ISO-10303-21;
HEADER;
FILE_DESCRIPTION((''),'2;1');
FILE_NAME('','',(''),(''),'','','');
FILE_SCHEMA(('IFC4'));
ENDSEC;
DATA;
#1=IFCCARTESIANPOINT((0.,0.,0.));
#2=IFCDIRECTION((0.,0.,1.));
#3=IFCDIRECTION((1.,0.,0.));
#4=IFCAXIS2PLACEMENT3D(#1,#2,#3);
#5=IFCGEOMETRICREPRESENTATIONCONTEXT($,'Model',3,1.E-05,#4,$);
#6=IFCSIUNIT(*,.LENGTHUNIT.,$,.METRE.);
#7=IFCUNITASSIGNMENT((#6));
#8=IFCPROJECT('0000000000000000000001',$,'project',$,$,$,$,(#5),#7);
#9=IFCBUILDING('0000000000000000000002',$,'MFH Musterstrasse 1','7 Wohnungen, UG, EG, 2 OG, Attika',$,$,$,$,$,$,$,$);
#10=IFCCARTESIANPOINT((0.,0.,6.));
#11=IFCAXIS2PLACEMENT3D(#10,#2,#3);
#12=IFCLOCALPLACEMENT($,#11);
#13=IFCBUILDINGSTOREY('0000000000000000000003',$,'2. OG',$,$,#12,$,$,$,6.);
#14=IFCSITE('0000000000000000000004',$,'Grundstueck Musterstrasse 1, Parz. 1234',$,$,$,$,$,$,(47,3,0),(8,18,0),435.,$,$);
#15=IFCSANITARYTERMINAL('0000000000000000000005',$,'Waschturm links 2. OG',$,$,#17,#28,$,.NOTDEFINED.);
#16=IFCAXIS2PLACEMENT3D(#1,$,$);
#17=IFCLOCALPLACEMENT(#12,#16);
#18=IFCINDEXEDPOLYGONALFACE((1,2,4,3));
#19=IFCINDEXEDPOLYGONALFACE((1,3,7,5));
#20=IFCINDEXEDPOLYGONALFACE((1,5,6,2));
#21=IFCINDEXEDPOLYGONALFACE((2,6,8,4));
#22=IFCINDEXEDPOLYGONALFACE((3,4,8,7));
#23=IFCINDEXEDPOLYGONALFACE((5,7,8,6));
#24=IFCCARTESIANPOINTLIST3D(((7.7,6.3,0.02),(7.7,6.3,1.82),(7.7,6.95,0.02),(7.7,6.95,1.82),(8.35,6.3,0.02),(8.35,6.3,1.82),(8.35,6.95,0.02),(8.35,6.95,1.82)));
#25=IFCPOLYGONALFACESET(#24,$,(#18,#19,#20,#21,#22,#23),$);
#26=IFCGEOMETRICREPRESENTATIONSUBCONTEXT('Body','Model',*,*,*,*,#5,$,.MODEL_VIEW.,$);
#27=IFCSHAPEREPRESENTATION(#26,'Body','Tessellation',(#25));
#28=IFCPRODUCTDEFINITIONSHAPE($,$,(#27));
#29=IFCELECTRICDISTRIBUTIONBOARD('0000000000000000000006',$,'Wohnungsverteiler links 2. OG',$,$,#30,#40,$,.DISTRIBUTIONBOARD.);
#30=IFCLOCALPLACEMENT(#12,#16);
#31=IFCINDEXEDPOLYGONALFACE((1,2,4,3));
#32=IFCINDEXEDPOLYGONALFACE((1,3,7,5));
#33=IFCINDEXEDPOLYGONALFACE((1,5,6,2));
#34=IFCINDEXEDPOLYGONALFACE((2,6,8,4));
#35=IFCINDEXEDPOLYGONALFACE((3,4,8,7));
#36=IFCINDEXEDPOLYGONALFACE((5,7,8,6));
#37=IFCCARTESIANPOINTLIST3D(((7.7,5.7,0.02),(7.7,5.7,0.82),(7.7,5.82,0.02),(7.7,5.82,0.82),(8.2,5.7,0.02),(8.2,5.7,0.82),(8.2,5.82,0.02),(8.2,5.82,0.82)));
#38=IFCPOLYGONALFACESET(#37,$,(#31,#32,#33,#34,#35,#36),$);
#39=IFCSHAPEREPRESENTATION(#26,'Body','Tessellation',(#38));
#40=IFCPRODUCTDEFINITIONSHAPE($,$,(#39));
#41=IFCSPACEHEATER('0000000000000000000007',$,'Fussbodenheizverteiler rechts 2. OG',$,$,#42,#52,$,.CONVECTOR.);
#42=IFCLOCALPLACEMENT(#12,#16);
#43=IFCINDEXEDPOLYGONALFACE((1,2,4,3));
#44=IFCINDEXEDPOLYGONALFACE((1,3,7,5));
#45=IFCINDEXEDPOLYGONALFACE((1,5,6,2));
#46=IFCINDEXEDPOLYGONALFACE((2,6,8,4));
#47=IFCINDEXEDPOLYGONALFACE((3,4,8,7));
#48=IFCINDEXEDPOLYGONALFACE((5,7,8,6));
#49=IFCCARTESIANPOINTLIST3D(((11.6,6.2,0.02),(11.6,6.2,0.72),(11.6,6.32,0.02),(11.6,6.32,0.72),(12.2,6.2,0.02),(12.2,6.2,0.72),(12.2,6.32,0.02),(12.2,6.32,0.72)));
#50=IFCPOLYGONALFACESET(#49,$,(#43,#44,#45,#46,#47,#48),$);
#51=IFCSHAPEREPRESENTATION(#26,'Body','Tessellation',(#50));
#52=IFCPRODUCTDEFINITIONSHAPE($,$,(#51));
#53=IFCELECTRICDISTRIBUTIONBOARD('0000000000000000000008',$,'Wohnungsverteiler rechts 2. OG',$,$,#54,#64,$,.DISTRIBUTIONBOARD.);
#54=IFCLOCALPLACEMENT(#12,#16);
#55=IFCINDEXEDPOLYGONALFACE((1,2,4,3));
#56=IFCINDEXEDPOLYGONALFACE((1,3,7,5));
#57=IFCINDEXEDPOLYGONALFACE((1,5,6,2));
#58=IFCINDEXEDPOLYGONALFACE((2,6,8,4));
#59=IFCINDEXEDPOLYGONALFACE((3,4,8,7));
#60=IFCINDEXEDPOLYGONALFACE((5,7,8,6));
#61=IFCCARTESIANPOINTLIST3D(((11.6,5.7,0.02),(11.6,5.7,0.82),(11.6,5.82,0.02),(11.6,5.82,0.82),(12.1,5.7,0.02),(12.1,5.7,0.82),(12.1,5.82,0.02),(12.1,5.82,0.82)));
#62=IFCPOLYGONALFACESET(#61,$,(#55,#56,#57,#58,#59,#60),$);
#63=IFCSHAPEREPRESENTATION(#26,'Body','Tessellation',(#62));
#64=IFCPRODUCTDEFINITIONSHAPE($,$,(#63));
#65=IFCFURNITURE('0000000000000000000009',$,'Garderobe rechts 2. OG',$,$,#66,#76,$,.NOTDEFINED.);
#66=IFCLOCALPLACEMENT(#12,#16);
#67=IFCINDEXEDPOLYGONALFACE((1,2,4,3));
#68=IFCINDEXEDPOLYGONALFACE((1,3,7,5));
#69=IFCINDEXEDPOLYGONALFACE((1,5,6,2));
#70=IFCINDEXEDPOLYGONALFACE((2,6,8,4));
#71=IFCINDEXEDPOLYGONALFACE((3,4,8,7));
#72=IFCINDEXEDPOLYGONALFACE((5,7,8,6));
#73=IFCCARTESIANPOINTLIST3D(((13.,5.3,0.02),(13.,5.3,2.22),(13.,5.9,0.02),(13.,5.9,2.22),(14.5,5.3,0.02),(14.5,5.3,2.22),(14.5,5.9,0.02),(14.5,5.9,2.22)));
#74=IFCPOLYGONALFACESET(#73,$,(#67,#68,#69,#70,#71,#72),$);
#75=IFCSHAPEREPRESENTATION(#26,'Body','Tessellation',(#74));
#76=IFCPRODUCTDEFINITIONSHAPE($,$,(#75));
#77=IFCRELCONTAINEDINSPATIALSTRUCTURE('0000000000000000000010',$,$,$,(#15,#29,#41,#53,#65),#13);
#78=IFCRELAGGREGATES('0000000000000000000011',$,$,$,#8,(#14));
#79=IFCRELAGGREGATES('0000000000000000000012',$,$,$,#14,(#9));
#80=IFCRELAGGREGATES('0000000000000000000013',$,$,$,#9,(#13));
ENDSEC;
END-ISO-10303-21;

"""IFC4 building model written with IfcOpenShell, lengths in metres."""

from ifc_helpers import new_model, si_unit, frame, frame_2d, origin_with_axes, place, context, subcontext, project, spatial, rectangle, extrude, element, save


model = new_model("IFC4")

# Units and contexts
model_context = context("Model", 3, precision=1e-05, world=origin_with_axes())
body_context = subcontext(model_context, "Body", "Model", "MODEL_VIEW")
ifc_project = project(units=[si_unit("LENGTHUNIT", "METRE")], contexts=[model_context])

# Site, building, storey
site = spatial("IfcSite", under=ifc_project, Name="Grundstueck Musterstrasse 1, Parz. 1234", RefLatitude=(47, 3, 0), RefLongitude=(8, 18, 0), RefElevation=435.0)
building = spatial("IfcBuilding", under=site, Name="MFH Musterstrasse 1", Description="7 Wohnungen, UG, EG, 2 OG, Attika")
storey_placement = place(None, frame((0.0, 0.0, 6.0), z_axis=(0.0, 0.0, 1.0), x_axis=(1.0, 0.0, 0.0)))
storey = spatial("IfcBuildingStorey", under=building, at=storey_placement, Name="2. OG", Elevation=6.0)

# Sanitary terminal
sanitary_terminal_placement = place(storey_placement, frame((7.7, 6.3, 0.02), z_axis=(0.0, 0.0, 1.0), x_axis=(1.0, 0.0, 0.0)))
element("IfcSanitaryTerminal", 1, at=sanitary_terminal_placement, inside=storey, Name="Waschturm links 2. OG", PredefinedType="NOTDEFINED", context=body_context, shape_type="SweptSolid", body=[
    extrude(rectangle(XDim=0.65, YDim=0.65, at=frame_2d((0.325, 0.325))), origin_with_axes(), (0.0, 0.0, 1.0), 1.8),
])

# Electric distribution board
electric_distribution_board_1_placement = place(storey_placement, frame((7.7, 5.7, 0.02), z_axis=(0.0, 0.0, 1.0), x_axis=(1.0, 0.0, 0.0)))
element("IfcElectricDistributionBoard", 2, at=electric_distribution_board_1_placement, inside=storey, Name="Wohnungsverteiler links 2. OG", PredefinedType="DISTRIBUTIONBOARD", context=body_context, shape_type="SweptSolid", body=[
    extrude(rectangle(XDim=0.5, YDim=0.12, at=frame_2d((0.25, 0.06))), origin_with_axes(), (0.0, 0.0, 1.0), 0.8),
])

# Space heater
space_heater_placement = place(storey_placement, frame((11.6, 6.2, 0.02), z_axis=(0.0, 0.0, 1.0), x_axis=(1.0, 0.0, 0.0)))
element("IfcSpaceHeater", 3, at=space_heater_placement, inside=storey, Name="Fussbodenheizverteiler rechts 2. OG", PredefinedType="CONVECTOR", context=body_context, shape_type="SweptSolid", body=[
    extrude(rectangle(XDim=0.6, YDim=0.12, at=frame_2d((0.3, 0.06))), origin_with_axes(), (0.0, 0.0, 1.0), 0.7),
])

# Electric distribution board
electric_distribution_board_2_placement = place(storey_placement, frame((11.6, 5.7, 0.02), z_axis=(0.0, 0.0, 1.0), x_axis=(1.0, 0.0, 0.0)))
element("IfcElectricDistributionBoard", 4, at=electric_distribution_board_2_placement, inside=storey, Name="Wohnungsverteiler rechts 2. OG", PredefinedType="DISTRIBUTIONBOARD", context=body_context, shape_type="SweptSolid", body=[
    extrude(rectangle(XDim=0.5, YDim=0.12, at=frame_2d((0.25, 0.06))), origin_with_axes(), (0.0, 0.0, 1.0), 0.8),
])

# Furniture
furniture_placement = place(storey_placement, frame((13.0, 5.3, 0.02), z_axis=(0.0, 0.0, 1.0), x_axis=(1.0, 0.0, 0.0)))
element("IfcFurniture", 5, at=furniture_placement, inside=storey, Name="Garderobe rechts 2. OG", PredefinedType="NOTDEFINED", context=body_context, shape_type="SweptSolid", body=[
    extrude(rectangle(XDim=1.5, YDim=0.6, at=frame_2d((0.75, 0.3))), origin_with_axes(), (0.0, 0.0, 1.0), 2.2),
])

save(model, "model.ifc")
